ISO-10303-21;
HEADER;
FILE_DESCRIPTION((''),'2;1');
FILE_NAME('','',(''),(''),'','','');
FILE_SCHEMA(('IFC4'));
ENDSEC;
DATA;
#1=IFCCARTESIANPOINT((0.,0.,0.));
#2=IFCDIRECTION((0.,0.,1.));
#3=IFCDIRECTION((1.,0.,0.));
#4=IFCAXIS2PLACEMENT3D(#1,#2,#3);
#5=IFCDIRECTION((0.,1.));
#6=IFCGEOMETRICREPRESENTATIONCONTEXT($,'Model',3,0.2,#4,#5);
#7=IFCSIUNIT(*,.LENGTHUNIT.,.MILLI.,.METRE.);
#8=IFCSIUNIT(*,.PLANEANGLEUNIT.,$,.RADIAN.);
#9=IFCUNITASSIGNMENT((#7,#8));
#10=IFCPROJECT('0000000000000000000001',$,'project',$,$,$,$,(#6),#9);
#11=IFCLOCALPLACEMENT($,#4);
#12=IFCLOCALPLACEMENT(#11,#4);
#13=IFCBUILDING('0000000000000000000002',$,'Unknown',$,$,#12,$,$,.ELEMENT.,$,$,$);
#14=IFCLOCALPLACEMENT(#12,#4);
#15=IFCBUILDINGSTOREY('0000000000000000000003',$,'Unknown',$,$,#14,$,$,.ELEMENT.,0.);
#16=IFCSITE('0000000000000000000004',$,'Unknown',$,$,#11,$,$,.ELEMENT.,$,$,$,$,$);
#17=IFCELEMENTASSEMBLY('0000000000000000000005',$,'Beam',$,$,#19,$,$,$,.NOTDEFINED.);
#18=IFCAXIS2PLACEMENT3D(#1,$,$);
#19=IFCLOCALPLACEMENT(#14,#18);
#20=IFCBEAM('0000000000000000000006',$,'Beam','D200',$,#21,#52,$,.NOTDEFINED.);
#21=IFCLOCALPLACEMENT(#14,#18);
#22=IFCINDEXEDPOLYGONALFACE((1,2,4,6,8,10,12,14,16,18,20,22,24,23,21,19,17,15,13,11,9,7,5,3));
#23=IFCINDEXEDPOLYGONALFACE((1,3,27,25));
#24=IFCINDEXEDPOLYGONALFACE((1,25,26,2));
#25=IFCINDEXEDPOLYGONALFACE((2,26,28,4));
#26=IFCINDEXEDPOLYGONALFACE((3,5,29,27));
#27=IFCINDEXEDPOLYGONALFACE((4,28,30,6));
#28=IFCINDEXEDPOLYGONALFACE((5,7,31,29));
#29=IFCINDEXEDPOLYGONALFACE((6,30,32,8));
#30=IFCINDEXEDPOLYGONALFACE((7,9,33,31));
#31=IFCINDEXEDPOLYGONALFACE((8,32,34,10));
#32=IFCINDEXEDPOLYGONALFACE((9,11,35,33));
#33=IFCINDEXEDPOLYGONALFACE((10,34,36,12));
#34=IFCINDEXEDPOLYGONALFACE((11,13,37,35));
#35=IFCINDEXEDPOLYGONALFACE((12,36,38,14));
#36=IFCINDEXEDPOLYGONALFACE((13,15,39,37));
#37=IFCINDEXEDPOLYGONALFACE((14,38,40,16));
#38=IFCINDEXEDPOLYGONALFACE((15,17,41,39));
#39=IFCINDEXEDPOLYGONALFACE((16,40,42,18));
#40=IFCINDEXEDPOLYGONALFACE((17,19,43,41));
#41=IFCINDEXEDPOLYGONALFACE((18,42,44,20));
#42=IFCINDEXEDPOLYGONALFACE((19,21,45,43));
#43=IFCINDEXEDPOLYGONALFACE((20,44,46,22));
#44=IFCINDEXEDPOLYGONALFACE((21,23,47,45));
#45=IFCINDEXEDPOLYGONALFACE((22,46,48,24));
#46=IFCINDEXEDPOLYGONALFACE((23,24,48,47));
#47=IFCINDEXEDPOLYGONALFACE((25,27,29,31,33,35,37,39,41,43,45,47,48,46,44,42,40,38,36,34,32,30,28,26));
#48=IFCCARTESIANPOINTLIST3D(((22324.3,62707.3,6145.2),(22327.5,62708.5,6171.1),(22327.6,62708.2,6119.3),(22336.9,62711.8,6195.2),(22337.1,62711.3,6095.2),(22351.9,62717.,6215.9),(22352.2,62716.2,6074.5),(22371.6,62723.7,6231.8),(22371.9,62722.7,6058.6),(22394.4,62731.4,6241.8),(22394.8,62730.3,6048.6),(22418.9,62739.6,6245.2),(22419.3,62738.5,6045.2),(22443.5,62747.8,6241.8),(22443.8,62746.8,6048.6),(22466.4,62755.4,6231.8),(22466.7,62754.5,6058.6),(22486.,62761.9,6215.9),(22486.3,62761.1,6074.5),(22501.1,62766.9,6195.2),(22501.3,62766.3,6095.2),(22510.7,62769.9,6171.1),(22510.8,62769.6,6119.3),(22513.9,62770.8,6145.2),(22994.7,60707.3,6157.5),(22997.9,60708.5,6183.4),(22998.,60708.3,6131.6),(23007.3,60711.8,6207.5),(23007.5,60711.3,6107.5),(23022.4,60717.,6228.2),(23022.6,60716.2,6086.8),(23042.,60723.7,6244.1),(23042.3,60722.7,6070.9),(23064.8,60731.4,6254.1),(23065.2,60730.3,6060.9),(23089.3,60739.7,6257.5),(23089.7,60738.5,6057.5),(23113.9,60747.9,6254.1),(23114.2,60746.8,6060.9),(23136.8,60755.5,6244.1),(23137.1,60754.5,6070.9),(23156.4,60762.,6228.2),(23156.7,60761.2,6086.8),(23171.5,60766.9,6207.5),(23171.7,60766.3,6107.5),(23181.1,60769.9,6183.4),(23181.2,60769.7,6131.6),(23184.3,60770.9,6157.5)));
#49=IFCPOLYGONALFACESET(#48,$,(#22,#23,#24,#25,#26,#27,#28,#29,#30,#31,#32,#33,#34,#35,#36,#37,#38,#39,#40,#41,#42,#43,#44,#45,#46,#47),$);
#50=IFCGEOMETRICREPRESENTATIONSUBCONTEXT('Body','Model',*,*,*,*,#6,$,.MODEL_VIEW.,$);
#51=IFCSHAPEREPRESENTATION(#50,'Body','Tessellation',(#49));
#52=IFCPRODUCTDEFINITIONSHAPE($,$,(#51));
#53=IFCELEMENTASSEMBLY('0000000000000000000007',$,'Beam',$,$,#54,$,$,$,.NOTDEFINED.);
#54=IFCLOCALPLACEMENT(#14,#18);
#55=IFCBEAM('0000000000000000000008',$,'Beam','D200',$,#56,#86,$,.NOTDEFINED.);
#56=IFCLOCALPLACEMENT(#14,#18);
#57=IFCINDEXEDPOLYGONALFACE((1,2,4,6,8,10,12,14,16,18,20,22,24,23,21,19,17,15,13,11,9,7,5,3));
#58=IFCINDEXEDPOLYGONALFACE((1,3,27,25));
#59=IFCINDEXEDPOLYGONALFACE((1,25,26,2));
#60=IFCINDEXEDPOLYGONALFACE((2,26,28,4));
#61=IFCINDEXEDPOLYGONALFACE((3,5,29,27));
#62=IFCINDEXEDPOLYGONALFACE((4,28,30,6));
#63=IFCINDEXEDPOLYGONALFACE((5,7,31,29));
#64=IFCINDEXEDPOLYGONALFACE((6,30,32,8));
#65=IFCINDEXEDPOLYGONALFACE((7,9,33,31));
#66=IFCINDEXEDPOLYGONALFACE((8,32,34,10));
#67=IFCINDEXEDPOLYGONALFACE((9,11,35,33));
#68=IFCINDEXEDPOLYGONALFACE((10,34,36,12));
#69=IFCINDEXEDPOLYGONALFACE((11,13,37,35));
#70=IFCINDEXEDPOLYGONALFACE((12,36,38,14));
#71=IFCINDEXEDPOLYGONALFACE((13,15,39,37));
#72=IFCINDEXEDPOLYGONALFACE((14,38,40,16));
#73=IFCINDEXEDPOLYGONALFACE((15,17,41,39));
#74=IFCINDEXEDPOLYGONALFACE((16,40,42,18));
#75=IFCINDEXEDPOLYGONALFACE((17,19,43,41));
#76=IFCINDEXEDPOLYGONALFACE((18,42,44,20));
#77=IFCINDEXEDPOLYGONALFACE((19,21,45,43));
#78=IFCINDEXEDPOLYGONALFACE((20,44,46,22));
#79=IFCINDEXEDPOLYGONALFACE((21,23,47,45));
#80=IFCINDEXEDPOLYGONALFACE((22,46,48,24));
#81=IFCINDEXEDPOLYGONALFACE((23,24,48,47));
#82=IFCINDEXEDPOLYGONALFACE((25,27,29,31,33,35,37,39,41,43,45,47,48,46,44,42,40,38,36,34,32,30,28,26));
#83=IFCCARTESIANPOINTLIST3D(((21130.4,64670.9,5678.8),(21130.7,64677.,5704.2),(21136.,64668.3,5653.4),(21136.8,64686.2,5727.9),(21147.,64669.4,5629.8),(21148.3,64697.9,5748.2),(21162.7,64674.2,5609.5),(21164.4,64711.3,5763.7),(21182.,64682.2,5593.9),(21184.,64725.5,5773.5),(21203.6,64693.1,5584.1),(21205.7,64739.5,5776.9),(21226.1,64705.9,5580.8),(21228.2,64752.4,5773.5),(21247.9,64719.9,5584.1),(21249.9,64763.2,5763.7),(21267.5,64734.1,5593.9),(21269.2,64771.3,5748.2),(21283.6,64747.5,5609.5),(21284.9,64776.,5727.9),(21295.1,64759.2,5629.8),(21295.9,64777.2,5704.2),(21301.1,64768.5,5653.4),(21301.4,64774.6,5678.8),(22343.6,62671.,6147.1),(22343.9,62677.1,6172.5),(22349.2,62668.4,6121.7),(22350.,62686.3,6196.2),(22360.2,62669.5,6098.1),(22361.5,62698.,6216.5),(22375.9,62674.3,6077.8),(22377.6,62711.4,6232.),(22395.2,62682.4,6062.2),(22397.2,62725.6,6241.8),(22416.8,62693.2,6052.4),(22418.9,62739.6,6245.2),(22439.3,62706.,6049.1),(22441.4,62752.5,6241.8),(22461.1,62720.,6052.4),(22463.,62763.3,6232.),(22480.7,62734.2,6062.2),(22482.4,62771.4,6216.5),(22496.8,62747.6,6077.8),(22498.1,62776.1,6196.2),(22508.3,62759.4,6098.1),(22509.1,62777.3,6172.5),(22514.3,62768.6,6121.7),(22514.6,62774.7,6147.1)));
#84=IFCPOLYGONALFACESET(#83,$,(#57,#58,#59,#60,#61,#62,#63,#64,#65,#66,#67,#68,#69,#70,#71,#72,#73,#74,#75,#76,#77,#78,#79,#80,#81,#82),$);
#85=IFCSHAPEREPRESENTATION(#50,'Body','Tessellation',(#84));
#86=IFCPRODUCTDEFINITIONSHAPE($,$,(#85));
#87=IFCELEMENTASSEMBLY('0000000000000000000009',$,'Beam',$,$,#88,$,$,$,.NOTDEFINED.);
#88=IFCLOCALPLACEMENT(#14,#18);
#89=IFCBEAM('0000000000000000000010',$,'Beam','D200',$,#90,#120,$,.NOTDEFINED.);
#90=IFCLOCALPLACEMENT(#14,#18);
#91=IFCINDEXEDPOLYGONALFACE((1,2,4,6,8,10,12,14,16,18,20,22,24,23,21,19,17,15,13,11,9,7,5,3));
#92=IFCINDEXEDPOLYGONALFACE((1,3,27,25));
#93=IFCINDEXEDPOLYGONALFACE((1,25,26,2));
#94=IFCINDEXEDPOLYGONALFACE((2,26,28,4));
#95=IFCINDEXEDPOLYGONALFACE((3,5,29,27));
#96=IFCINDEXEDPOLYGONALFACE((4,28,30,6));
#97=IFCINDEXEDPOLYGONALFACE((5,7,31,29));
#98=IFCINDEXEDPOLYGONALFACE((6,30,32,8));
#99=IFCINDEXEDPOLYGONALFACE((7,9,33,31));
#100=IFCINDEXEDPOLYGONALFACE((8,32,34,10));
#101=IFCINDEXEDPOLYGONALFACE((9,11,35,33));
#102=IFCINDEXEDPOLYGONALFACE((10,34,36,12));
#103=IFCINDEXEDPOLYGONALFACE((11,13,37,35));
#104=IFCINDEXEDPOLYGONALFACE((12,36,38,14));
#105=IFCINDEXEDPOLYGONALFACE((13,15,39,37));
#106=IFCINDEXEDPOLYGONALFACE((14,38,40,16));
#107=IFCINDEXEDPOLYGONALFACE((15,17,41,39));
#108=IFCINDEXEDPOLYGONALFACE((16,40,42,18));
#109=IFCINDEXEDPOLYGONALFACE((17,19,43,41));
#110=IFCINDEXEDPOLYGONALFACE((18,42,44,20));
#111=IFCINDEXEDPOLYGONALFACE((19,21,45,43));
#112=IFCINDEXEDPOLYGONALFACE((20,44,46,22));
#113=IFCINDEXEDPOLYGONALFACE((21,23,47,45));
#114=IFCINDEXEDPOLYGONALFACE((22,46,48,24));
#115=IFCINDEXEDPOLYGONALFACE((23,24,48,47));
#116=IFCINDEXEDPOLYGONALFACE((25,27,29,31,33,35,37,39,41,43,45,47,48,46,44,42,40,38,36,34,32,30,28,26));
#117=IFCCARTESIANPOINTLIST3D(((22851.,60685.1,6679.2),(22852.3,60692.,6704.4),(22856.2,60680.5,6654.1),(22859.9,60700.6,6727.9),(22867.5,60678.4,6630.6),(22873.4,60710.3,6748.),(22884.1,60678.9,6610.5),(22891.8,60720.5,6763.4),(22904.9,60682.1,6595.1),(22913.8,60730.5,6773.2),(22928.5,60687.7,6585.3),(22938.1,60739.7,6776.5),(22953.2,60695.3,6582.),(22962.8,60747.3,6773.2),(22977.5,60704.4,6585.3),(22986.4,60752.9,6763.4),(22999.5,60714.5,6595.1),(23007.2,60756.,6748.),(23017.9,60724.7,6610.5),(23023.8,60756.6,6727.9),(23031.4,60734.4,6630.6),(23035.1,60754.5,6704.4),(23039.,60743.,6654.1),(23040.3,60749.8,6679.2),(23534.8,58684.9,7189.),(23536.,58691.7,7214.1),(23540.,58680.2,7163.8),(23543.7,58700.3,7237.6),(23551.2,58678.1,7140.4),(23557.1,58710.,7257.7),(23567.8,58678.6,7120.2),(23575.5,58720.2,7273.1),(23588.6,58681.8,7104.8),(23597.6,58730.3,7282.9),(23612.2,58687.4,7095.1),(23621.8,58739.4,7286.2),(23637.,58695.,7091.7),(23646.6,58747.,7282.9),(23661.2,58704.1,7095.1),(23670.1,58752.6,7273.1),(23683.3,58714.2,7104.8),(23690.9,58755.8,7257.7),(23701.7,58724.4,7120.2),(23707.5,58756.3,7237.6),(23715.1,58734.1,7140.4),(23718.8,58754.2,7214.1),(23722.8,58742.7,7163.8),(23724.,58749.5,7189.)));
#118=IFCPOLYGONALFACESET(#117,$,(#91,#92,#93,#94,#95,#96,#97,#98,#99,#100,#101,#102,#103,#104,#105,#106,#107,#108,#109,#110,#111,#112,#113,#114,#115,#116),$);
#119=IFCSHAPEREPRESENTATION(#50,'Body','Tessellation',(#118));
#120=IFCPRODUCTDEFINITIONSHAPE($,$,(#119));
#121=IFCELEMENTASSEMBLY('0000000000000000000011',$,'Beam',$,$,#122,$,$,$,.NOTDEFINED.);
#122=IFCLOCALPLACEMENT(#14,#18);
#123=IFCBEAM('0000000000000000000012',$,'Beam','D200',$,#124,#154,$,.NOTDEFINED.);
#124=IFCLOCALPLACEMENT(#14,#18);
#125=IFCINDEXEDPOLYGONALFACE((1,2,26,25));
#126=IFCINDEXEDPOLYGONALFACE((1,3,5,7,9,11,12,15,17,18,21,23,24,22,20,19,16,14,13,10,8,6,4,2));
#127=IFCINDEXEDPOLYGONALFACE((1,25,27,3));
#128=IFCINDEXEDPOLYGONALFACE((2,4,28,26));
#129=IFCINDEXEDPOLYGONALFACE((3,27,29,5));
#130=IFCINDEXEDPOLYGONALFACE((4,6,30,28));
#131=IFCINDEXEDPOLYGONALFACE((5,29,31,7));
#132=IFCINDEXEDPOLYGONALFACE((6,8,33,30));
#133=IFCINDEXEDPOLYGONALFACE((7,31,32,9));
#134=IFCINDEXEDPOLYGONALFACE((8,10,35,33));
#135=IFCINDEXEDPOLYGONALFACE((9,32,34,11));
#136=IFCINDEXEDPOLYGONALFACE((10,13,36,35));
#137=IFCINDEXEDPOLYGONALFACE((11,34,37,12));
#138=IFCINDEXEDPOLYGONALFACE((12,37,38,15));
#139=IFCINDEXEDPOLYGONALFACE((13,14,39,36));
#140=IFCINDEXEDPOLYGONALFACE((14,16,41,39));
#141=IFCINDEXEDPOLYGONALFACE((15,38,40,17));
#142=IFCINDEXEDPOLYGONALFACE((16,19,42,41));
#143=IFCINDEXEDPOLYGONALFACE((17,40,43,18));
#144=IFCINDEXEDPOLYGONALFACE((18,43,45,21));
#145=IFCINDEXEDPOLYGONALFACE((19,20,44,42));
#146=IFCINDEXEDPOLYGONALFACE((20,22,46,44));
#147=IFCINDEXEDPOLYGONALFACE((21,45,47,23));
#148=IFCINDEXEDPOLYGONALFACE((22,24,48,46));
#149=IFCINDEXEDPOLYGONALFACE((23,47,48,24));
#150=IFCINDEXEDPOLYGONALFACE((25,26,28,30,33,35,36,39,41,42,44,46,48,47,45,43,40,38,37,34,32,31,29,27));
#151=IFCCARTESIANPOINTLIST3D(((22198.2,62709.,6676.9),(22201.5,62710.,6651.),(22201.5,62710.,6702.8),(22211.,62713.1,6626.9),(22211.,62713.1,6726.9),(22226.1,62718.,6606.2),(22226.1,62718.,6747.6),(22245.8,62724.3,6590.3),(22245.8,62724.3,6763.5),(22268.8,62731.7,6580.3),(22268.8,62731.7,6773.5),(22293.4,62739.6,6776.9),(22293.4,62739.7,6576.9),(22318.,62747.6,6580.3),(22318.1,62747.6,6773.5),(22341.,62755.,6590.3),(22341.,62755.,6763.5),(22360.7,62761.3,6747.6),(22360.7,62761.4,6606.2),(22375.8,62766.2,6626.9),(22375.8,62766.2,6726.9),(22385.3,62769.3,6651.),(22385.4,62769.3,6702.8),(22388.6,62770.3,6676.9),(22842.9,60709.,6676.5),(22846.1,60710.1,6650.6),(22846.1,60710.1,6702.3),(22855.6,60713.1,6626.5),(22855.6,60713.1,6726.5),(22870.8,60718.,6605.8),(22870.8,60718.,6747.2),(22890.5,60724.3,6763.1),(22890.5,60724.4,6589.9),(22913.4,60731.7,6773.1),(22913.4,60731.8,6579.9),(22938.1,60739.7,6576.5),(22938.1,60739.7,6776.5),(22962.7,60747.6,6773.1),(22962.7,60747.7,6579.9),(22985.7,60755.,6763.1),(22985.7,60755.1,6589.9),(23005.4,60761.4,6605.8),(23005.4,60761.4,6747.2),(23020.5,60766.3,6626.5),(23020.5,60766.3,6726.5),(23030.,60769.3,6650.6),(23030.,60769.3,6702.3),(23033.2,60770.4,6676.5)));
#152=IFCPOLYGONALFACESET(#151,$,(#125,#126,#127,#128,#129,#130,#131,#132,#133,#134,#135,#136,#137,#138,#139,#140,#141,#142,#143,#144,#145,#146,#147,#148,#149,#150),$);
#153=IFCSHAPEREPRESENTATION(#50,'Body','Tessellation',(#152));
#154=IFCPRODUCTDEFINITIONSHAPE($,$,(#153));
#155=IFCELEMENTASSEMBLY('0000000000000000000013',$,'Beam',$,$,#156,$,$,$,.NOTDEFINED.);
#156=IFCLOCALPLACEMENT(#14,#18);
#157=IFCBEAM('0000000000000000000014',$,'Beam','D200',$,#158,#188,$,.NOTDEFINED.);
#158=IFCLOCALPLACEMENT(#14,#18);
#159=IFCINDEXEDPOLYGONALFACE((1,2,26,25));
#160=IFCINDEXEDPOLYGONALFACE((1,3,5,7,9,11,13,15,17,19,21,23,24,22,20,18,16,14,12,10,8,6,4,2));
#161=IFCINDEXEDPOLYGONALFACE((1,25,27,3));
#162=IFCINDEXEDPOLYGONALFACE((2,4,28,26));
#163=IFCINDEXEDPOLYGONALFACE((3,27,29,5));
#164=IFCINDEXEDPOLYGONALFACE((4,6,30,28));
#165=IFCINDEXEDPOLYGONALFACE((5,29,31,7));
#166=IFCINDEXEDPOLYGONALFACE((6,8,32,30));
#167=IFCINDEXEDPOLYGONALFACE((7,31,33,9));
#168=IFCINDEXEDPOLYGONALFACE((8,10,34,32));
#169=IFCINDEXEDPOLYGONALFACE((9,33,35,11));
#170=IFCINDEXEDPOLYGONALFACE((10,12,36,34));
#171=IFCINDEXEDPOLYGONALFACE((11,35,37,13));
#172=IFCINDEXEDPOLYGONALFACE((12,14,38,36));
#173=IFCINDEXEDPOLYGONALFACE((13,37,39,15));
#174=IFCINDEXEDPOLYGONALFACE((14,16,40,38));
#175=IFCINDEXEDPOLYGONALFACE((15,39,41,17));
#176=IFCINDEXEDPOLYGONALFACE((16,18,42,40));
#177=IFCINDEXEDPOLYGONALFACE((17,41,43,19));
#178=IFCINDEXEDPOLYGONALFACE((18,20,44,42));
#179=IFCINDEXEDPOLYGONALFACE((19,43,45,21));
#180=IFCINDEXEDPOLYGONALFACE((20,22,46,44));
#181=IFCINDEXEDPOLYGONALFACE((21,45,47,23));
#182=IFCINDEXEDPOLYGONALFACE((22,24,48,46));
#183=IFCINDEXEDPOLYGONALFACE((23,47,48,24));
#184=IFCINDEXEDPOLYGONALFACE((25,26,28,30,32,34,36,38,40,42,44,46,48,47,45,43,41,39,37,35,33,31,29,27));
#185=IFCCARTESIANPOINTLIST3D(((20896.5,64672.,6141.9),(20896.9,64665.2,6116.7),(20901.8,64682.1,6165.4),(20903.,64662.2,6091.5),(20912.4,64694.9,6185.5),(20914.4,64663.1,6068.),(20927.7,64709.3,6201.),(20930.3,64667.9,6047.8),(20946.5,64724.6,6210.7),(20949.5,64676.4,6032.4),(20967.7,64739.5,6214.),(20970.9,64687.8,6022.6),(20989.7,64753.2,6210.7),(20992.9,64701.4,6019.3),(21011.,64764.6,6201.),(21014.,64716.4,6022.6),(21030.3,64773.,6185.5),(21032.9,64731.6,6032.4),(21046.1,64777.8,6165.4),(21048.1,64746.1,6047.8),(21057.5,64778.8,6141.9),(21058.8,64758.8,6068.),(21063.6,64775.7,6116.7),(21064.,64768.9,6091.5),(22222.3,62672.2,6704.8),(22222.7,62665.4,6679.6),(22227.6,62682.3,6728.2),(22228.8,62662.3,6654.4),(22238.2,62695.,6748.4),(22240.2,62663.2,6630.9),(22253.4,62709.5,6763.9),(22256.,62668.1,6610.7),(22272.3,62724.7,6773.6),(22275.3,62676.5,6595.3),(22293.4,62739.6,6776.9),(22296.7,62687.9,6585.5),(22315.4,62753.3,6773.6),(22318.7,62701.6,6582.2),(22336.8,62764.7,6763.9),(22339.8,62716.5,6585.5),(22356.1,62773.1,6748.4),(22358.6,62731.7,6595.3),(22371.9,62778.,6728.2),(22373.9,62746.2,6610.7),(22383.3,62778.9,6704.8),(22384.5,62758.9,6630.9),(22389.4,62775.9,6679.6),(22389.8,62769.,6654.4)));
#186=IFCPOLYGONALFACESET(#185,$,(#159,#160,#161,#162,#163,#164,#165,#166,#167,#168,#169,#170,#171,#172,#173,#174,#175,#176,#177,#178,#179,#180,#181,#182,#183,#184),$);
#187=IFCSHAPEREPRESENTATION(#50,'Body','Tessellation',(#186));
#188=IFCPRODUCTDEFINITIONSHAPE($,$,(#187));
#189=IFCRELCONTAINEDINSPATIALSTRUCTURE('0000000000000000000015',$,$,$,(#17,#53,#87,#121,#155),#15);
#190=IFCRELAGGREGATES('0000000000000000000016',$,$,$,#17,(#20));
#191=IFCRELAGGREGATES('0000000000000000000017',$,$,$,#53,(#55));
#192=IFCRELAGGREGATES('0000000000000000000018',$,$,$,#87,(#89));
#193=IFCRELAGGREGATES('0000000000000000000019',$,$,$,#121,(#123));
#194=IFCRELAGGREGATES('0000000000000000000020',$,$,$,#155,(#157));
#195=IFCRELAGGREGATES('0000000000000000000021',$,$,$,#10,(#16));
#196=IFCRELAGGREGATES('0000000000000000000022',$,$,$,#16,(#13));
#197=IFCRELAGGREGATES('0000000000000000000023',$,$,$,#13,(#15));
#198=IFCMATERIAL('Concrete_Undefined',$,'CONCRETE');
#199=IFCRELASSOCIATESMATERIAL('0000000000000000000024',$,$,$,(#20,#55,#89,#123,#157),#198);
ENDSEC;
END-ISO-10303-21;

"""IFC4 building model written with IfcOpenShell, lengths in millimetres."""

from ifc_helpers import new_model, si_unit, direction, frame, origin_with_axes, place, context, subcontext, project, spatial, line, indexed_curve, outline, extrude, material, element, aggregate, save


model = new_model("IFC4")

# Units and contexts
model_context = context("Model", 3, precision=0.2, world=origin_with_axes(), true_north=direction((0.0, 1.0)))
body_context = subcontext(model_context, "Body", "Model", "MODEL_VIEW")
ifc_project = project(units=[si_unit("LENGTHUNIT", "METRE", prefix="MILLI"), si_unit("PLANEANGLEUNIT", "RADIAN")], contexts=[model_context])

# Site, building, storey
site_placement = place(None, origin_with_axes())
site = spatial("IfcSite", under=ifc_project, at=site_placement, Name="Unknown", CompositionType="ELEMENT")
building_placement = place(site_placement, origin_with_axes())
building = spatial("IfcBuilding", under=site, at=building_placement, Name="Unknown", CompositionType="ELEMENT")
storey_placement = place(building_placement, origin_with_axes())
storey = spatial("IfcBuildingStorey", under=building, at=storey_placement, Name="Unknown", CompositionType="ELEMENT", Elevation=0.0)

# Element assemblies, beams
ifc_material = material(Name="Concrete_Undefined", Category="CONCRETE")
assembly_1_placement = place(storey_placement, frame((22419.1, 62739.1, 6145.2), z_axis=(-0.948149, -0.317827, 0.0), x_axis=(0.317822, -0.948132, 0.005852)))
assembly_1 = element("IfcElementAssembly", 1, at=assembly_1_placement, inside=storey, Name="Beam", PredefinedType="NOTDEFINED")
beam_1_placement = place(assembly_1_placement, origin_with_axes())
beam_1 = element("IfcBeam", 2, at=beam_1_placement, material=ifc_material, Name="Beam", Description="D200", PredefinedType="NOTDEFINED", context=body_context, shape_type="SolidModel", body=[
    extrude(outline(indexed_curve([(100.0, 0.0), (96.6, 25.9), (86.6, 50.0), (70.7, 70.7), (50.0, 86.6), (25.9, 96.6), (0.0, 100.0), (-25.9, 96.6), (-50.0, 86.6), (-70.7, 70.7), (-86.6, 50.0), (-96.6, 25.9), (-100.0, 0.0), (-96.6, -25.9), (-86.6, -50.0), (-70.7, -70.7), (-50.0, -86.6), (-25.9, -96.6), (0.0, -100.0), (25.9, -96.6), (50.0, -86.6), (70.7, -70.7), (86.6, -50.0), (96.6, -25.9)], segments=[line(1, 2, 3, 4, 5, 6, 7, 8, 9, 10, 11, 12, 13, 14, 15, 16, 17, 18, 19, 20, 21, 22, 23, 24, 1)])), frame((0.0, 0.0, 0.0), z_axis=(-1.0, 0.0, 0.0), x_axis=(0.0, 0.0, 1.0)), (0.0, 0.0, -1.0), 2109.4),
])
aggregate(assembly_1, [beam_1])
assembly_2_placement = place(storey_placement, frame((21215.9, 64722.7, 5678.8), z_axis=(-0.854982, -0.518658, 0.0), x_axis=(0.508566, -0.838345, 0.196311)))
assembly_2 = element("IfcElementAssembly", 3, at=assembly_2_placement, inside=storey, Name="Beam", PredefinedType="NOTDEFINED")
beam_2_placement = place(assembly_2_placement, origin_with_axes())
beam_2 = element("IfcBeam", 4, at=beam_2_placement, material=ifc_material, Name="Beam", Description="D200", PredefinedType="NOTDEFINED", context=body_context, shape_type="SolidModel", body=[
    extrude(outline(indexed_curve([(100.0, 0.0), (96.6, 25.9), (86.6, 50.0), (70.7, 70.7), (50.0, 86.6), (25.9, 96.6), (0.0, 100.0), (-25.9, 96.6), (-50.0, 86.6), (-70.7, 70.7), (-86.6, 50.0), (-96.6, 25.9), (-100.0, 0.0), (-96.6, -25.9), (-86.6, -50.0), (-70.7, -70.7), (-50.0, -86.6), (-25.9, -96.6), (0.0, -100.0), (25.9, -96.6), (50.0, -86.6), (70.7, -70.7), (86.6, -50.0), (96.6, -25.9)], segments=[line(1, 2, 3, 4, 5, 6, 7, 8, 9, 10, 11, 12, 13, 14, 15, 16, 17, 18, 19, 20, 21, 22, 23, 24, 1)])), frame((0.0, 0.0, 0.0), z_axis=(-1.0, 0.0, 0.0), x_axis=(0.0, 0.0, 1.0)), (0.0, 0.0, -1.0), 2385.5),
])
aggregate(assembly_2, [beam_2])
assembly_3_placement = place(storey_placement, frame((22945.7, 60717.5, 6679.2), z_axis=(-0.946248, -0.323443, 0.0), x_axis=(0.314432, -0.919884, 0.234404)))
assembly_3 = element("IfcElementAssembly", 5, at=assembly_3_placement, inside=storey, Name="Beam", PredefinedType="NOTDEFINED")
beam_3_placement = place(assembly_3_placement, origin_with_axes())
beam_3 = element("IfcBeam", 6, at=beam_3_placement, material=ifc_material, Name="Beam", Description="D200", PredefinedType="NOTDEFINED", context=body_context, shape_type="SolidModel", body=[
    extrude(outline(indexed_curve([(100.0, 0.0), (96.6, 25.9), (86.6, 50.0), (70.7, 70.7), (50.0, 86.6), (25.9, 96.6), (0.0, 100.0), (-25.9, 96.6), (-50.0, 86.6), (-70.7, 70.7), (-86.6, 50.0), (-96.6, 25.9), (-100.0, 0.0), (-96.6, -25.9), (-86.6, -50.0), (-70.7, -70.7), (-50.0, -86.6), (-25.9, -96.6), (0.0, -100.0), (25.9, -96.6), (50.0, -86.6), (70.7, -70.7), (86.6, -50.0), (96.6, -25.9)], segments=[line(1, 2, 3, 4, 5, 6, 7, 8, 9, 10, 11, 12, 13, 14, 15, 16, 17, 18, 19, 20, 21, 22, 23, 24, 1)])), frame((0.0, 0.0, 0.0), z_axis=(-1.0, 0.0, 0.0), x_axis=(0.0, 0.0, 1.0)), (0.0, 0.0, -1.0), 2174.5),
])
aggregate(assembly_3, [beam_3])
assembly_4_placement = place(storey_placement, frame((22293.4, 62739.7, 6676.9), z_axis=(-0.951778, -0.306788, 0.0), x_axis=(0.306788, -0.951778, -0.000219)))
assembly_4 = element("IfcElementAssembly", 7, at=assembly_4_placement, inside=storey, Name="Beam", PredefinedType="NOTDEFINED")
beam_4_placement = place(assembly_4_placement, origin_with_axes())
beam_4 = element("IfcBeam", 8, at=beam_4_placement, material=ifc_material, Name="Beam", Description="D200", PredefinedType="NOTDEFINED", context=body_context, shape_type="SolidModel", body=[
    extrude(outline(indexed_curve([(100.0, 0.0), (96.6, 25.9), (86.6, 50.0), (70.7, 70.7), (50.0, 86.6), (25.9, 96.6), (0.0, 100.0), (-25.9, 96.6), (-50.0, 86.6), (-70.7, 70.7), (-86.6, 50.0), (-96.6, 25.9), (-100.0, 0.0), (-96.6, -25.9), (-86.6, -50.0), (-70.7, -70.7), (-50.0, -86.6), (-25.9, -96.6), (0.0, -100.0), (25.9, -96.6), (50.0, -86.6), (70.7, -70.7), (86.6, -50.0), (96.6, -25.9)], segments=[line(1, 2, 3, 4, 5, 6, 7, 8, 9, 10, 11, 12, 13, 14, 15, 16, 17, 18, 19, 20, 21, 22, 23, 24, 1)])), frame((0.0, 0.0, 0.0), z_axis=(-1.0, 0.0, 0.0), x_axis=(0.0, 0.0, 1.0)), (0.0, 0.0, -1.0), 2101.3),
])
aggregate(assembly_4, [beam_4])
assembly_5_placement = place(storey_placement, frame((20980.3, 64720.5, 6116.7), z_axis=(-0.833486, -0.552541, 0.0), x_axis=(0.537937, -0.811456, 0.228393)))
assembly_5 = element("IfcElementAssembly", 9, at=assembly_5_placement, inside=storey, Name="Beam", PredefinedType="NOTDEFINED")
beam_5_placement = place(assembly_5_placement, origin_with_axes())
beam_5 = element("IfcBeam", 10, at=beam_5_placement, material=ifc_material, Name="Beam", Description="D200", PredefinedType="NOTDEFINED", context=body_context, shape_type="SolidModel", body=[
    extrude(outline(indexed_curve([(100.0, 0.0), (96.6, 25.9), (86.6, 50.0), (70.7, 70.7), (50.0, 86.6), (25.9, 96.6), (0.0, 100.0), (-25.9, 96.6), (-50.0, 86.6), (-70.7, 70.7), (-86.6, 50.0), (-96.6, 25.9), (-100.0, 0.0), (-96.6, -25.9), (-86.6, -50.0), (-70.7, -70.7), (-50.0, -86.6), (-25.9, -96.6), (0.0, -100.0), (25.9, -96.6), (50.0, -86.6), (70.7, -70.7), (86.6, -50.0), (96.6, -25.9)], segments=[line(1, 2, 3, 4, 5, 6, 7, 8, 9, 10, 11, 12, 13, 14, 15, 16, 17, 18, 19, 20, 21, 22, 23, 24, 1)])), frame((0.0, 0.0, 0.0), z_axis=(-1.0, 0.0, 0.0), x_axis=(0.0, 0.0, 1.0)), (0.0, 0.0, -1.0), 2464.5),
])
aggregate(assembly_5, [beam_5])

save(model, "model.ifc")
